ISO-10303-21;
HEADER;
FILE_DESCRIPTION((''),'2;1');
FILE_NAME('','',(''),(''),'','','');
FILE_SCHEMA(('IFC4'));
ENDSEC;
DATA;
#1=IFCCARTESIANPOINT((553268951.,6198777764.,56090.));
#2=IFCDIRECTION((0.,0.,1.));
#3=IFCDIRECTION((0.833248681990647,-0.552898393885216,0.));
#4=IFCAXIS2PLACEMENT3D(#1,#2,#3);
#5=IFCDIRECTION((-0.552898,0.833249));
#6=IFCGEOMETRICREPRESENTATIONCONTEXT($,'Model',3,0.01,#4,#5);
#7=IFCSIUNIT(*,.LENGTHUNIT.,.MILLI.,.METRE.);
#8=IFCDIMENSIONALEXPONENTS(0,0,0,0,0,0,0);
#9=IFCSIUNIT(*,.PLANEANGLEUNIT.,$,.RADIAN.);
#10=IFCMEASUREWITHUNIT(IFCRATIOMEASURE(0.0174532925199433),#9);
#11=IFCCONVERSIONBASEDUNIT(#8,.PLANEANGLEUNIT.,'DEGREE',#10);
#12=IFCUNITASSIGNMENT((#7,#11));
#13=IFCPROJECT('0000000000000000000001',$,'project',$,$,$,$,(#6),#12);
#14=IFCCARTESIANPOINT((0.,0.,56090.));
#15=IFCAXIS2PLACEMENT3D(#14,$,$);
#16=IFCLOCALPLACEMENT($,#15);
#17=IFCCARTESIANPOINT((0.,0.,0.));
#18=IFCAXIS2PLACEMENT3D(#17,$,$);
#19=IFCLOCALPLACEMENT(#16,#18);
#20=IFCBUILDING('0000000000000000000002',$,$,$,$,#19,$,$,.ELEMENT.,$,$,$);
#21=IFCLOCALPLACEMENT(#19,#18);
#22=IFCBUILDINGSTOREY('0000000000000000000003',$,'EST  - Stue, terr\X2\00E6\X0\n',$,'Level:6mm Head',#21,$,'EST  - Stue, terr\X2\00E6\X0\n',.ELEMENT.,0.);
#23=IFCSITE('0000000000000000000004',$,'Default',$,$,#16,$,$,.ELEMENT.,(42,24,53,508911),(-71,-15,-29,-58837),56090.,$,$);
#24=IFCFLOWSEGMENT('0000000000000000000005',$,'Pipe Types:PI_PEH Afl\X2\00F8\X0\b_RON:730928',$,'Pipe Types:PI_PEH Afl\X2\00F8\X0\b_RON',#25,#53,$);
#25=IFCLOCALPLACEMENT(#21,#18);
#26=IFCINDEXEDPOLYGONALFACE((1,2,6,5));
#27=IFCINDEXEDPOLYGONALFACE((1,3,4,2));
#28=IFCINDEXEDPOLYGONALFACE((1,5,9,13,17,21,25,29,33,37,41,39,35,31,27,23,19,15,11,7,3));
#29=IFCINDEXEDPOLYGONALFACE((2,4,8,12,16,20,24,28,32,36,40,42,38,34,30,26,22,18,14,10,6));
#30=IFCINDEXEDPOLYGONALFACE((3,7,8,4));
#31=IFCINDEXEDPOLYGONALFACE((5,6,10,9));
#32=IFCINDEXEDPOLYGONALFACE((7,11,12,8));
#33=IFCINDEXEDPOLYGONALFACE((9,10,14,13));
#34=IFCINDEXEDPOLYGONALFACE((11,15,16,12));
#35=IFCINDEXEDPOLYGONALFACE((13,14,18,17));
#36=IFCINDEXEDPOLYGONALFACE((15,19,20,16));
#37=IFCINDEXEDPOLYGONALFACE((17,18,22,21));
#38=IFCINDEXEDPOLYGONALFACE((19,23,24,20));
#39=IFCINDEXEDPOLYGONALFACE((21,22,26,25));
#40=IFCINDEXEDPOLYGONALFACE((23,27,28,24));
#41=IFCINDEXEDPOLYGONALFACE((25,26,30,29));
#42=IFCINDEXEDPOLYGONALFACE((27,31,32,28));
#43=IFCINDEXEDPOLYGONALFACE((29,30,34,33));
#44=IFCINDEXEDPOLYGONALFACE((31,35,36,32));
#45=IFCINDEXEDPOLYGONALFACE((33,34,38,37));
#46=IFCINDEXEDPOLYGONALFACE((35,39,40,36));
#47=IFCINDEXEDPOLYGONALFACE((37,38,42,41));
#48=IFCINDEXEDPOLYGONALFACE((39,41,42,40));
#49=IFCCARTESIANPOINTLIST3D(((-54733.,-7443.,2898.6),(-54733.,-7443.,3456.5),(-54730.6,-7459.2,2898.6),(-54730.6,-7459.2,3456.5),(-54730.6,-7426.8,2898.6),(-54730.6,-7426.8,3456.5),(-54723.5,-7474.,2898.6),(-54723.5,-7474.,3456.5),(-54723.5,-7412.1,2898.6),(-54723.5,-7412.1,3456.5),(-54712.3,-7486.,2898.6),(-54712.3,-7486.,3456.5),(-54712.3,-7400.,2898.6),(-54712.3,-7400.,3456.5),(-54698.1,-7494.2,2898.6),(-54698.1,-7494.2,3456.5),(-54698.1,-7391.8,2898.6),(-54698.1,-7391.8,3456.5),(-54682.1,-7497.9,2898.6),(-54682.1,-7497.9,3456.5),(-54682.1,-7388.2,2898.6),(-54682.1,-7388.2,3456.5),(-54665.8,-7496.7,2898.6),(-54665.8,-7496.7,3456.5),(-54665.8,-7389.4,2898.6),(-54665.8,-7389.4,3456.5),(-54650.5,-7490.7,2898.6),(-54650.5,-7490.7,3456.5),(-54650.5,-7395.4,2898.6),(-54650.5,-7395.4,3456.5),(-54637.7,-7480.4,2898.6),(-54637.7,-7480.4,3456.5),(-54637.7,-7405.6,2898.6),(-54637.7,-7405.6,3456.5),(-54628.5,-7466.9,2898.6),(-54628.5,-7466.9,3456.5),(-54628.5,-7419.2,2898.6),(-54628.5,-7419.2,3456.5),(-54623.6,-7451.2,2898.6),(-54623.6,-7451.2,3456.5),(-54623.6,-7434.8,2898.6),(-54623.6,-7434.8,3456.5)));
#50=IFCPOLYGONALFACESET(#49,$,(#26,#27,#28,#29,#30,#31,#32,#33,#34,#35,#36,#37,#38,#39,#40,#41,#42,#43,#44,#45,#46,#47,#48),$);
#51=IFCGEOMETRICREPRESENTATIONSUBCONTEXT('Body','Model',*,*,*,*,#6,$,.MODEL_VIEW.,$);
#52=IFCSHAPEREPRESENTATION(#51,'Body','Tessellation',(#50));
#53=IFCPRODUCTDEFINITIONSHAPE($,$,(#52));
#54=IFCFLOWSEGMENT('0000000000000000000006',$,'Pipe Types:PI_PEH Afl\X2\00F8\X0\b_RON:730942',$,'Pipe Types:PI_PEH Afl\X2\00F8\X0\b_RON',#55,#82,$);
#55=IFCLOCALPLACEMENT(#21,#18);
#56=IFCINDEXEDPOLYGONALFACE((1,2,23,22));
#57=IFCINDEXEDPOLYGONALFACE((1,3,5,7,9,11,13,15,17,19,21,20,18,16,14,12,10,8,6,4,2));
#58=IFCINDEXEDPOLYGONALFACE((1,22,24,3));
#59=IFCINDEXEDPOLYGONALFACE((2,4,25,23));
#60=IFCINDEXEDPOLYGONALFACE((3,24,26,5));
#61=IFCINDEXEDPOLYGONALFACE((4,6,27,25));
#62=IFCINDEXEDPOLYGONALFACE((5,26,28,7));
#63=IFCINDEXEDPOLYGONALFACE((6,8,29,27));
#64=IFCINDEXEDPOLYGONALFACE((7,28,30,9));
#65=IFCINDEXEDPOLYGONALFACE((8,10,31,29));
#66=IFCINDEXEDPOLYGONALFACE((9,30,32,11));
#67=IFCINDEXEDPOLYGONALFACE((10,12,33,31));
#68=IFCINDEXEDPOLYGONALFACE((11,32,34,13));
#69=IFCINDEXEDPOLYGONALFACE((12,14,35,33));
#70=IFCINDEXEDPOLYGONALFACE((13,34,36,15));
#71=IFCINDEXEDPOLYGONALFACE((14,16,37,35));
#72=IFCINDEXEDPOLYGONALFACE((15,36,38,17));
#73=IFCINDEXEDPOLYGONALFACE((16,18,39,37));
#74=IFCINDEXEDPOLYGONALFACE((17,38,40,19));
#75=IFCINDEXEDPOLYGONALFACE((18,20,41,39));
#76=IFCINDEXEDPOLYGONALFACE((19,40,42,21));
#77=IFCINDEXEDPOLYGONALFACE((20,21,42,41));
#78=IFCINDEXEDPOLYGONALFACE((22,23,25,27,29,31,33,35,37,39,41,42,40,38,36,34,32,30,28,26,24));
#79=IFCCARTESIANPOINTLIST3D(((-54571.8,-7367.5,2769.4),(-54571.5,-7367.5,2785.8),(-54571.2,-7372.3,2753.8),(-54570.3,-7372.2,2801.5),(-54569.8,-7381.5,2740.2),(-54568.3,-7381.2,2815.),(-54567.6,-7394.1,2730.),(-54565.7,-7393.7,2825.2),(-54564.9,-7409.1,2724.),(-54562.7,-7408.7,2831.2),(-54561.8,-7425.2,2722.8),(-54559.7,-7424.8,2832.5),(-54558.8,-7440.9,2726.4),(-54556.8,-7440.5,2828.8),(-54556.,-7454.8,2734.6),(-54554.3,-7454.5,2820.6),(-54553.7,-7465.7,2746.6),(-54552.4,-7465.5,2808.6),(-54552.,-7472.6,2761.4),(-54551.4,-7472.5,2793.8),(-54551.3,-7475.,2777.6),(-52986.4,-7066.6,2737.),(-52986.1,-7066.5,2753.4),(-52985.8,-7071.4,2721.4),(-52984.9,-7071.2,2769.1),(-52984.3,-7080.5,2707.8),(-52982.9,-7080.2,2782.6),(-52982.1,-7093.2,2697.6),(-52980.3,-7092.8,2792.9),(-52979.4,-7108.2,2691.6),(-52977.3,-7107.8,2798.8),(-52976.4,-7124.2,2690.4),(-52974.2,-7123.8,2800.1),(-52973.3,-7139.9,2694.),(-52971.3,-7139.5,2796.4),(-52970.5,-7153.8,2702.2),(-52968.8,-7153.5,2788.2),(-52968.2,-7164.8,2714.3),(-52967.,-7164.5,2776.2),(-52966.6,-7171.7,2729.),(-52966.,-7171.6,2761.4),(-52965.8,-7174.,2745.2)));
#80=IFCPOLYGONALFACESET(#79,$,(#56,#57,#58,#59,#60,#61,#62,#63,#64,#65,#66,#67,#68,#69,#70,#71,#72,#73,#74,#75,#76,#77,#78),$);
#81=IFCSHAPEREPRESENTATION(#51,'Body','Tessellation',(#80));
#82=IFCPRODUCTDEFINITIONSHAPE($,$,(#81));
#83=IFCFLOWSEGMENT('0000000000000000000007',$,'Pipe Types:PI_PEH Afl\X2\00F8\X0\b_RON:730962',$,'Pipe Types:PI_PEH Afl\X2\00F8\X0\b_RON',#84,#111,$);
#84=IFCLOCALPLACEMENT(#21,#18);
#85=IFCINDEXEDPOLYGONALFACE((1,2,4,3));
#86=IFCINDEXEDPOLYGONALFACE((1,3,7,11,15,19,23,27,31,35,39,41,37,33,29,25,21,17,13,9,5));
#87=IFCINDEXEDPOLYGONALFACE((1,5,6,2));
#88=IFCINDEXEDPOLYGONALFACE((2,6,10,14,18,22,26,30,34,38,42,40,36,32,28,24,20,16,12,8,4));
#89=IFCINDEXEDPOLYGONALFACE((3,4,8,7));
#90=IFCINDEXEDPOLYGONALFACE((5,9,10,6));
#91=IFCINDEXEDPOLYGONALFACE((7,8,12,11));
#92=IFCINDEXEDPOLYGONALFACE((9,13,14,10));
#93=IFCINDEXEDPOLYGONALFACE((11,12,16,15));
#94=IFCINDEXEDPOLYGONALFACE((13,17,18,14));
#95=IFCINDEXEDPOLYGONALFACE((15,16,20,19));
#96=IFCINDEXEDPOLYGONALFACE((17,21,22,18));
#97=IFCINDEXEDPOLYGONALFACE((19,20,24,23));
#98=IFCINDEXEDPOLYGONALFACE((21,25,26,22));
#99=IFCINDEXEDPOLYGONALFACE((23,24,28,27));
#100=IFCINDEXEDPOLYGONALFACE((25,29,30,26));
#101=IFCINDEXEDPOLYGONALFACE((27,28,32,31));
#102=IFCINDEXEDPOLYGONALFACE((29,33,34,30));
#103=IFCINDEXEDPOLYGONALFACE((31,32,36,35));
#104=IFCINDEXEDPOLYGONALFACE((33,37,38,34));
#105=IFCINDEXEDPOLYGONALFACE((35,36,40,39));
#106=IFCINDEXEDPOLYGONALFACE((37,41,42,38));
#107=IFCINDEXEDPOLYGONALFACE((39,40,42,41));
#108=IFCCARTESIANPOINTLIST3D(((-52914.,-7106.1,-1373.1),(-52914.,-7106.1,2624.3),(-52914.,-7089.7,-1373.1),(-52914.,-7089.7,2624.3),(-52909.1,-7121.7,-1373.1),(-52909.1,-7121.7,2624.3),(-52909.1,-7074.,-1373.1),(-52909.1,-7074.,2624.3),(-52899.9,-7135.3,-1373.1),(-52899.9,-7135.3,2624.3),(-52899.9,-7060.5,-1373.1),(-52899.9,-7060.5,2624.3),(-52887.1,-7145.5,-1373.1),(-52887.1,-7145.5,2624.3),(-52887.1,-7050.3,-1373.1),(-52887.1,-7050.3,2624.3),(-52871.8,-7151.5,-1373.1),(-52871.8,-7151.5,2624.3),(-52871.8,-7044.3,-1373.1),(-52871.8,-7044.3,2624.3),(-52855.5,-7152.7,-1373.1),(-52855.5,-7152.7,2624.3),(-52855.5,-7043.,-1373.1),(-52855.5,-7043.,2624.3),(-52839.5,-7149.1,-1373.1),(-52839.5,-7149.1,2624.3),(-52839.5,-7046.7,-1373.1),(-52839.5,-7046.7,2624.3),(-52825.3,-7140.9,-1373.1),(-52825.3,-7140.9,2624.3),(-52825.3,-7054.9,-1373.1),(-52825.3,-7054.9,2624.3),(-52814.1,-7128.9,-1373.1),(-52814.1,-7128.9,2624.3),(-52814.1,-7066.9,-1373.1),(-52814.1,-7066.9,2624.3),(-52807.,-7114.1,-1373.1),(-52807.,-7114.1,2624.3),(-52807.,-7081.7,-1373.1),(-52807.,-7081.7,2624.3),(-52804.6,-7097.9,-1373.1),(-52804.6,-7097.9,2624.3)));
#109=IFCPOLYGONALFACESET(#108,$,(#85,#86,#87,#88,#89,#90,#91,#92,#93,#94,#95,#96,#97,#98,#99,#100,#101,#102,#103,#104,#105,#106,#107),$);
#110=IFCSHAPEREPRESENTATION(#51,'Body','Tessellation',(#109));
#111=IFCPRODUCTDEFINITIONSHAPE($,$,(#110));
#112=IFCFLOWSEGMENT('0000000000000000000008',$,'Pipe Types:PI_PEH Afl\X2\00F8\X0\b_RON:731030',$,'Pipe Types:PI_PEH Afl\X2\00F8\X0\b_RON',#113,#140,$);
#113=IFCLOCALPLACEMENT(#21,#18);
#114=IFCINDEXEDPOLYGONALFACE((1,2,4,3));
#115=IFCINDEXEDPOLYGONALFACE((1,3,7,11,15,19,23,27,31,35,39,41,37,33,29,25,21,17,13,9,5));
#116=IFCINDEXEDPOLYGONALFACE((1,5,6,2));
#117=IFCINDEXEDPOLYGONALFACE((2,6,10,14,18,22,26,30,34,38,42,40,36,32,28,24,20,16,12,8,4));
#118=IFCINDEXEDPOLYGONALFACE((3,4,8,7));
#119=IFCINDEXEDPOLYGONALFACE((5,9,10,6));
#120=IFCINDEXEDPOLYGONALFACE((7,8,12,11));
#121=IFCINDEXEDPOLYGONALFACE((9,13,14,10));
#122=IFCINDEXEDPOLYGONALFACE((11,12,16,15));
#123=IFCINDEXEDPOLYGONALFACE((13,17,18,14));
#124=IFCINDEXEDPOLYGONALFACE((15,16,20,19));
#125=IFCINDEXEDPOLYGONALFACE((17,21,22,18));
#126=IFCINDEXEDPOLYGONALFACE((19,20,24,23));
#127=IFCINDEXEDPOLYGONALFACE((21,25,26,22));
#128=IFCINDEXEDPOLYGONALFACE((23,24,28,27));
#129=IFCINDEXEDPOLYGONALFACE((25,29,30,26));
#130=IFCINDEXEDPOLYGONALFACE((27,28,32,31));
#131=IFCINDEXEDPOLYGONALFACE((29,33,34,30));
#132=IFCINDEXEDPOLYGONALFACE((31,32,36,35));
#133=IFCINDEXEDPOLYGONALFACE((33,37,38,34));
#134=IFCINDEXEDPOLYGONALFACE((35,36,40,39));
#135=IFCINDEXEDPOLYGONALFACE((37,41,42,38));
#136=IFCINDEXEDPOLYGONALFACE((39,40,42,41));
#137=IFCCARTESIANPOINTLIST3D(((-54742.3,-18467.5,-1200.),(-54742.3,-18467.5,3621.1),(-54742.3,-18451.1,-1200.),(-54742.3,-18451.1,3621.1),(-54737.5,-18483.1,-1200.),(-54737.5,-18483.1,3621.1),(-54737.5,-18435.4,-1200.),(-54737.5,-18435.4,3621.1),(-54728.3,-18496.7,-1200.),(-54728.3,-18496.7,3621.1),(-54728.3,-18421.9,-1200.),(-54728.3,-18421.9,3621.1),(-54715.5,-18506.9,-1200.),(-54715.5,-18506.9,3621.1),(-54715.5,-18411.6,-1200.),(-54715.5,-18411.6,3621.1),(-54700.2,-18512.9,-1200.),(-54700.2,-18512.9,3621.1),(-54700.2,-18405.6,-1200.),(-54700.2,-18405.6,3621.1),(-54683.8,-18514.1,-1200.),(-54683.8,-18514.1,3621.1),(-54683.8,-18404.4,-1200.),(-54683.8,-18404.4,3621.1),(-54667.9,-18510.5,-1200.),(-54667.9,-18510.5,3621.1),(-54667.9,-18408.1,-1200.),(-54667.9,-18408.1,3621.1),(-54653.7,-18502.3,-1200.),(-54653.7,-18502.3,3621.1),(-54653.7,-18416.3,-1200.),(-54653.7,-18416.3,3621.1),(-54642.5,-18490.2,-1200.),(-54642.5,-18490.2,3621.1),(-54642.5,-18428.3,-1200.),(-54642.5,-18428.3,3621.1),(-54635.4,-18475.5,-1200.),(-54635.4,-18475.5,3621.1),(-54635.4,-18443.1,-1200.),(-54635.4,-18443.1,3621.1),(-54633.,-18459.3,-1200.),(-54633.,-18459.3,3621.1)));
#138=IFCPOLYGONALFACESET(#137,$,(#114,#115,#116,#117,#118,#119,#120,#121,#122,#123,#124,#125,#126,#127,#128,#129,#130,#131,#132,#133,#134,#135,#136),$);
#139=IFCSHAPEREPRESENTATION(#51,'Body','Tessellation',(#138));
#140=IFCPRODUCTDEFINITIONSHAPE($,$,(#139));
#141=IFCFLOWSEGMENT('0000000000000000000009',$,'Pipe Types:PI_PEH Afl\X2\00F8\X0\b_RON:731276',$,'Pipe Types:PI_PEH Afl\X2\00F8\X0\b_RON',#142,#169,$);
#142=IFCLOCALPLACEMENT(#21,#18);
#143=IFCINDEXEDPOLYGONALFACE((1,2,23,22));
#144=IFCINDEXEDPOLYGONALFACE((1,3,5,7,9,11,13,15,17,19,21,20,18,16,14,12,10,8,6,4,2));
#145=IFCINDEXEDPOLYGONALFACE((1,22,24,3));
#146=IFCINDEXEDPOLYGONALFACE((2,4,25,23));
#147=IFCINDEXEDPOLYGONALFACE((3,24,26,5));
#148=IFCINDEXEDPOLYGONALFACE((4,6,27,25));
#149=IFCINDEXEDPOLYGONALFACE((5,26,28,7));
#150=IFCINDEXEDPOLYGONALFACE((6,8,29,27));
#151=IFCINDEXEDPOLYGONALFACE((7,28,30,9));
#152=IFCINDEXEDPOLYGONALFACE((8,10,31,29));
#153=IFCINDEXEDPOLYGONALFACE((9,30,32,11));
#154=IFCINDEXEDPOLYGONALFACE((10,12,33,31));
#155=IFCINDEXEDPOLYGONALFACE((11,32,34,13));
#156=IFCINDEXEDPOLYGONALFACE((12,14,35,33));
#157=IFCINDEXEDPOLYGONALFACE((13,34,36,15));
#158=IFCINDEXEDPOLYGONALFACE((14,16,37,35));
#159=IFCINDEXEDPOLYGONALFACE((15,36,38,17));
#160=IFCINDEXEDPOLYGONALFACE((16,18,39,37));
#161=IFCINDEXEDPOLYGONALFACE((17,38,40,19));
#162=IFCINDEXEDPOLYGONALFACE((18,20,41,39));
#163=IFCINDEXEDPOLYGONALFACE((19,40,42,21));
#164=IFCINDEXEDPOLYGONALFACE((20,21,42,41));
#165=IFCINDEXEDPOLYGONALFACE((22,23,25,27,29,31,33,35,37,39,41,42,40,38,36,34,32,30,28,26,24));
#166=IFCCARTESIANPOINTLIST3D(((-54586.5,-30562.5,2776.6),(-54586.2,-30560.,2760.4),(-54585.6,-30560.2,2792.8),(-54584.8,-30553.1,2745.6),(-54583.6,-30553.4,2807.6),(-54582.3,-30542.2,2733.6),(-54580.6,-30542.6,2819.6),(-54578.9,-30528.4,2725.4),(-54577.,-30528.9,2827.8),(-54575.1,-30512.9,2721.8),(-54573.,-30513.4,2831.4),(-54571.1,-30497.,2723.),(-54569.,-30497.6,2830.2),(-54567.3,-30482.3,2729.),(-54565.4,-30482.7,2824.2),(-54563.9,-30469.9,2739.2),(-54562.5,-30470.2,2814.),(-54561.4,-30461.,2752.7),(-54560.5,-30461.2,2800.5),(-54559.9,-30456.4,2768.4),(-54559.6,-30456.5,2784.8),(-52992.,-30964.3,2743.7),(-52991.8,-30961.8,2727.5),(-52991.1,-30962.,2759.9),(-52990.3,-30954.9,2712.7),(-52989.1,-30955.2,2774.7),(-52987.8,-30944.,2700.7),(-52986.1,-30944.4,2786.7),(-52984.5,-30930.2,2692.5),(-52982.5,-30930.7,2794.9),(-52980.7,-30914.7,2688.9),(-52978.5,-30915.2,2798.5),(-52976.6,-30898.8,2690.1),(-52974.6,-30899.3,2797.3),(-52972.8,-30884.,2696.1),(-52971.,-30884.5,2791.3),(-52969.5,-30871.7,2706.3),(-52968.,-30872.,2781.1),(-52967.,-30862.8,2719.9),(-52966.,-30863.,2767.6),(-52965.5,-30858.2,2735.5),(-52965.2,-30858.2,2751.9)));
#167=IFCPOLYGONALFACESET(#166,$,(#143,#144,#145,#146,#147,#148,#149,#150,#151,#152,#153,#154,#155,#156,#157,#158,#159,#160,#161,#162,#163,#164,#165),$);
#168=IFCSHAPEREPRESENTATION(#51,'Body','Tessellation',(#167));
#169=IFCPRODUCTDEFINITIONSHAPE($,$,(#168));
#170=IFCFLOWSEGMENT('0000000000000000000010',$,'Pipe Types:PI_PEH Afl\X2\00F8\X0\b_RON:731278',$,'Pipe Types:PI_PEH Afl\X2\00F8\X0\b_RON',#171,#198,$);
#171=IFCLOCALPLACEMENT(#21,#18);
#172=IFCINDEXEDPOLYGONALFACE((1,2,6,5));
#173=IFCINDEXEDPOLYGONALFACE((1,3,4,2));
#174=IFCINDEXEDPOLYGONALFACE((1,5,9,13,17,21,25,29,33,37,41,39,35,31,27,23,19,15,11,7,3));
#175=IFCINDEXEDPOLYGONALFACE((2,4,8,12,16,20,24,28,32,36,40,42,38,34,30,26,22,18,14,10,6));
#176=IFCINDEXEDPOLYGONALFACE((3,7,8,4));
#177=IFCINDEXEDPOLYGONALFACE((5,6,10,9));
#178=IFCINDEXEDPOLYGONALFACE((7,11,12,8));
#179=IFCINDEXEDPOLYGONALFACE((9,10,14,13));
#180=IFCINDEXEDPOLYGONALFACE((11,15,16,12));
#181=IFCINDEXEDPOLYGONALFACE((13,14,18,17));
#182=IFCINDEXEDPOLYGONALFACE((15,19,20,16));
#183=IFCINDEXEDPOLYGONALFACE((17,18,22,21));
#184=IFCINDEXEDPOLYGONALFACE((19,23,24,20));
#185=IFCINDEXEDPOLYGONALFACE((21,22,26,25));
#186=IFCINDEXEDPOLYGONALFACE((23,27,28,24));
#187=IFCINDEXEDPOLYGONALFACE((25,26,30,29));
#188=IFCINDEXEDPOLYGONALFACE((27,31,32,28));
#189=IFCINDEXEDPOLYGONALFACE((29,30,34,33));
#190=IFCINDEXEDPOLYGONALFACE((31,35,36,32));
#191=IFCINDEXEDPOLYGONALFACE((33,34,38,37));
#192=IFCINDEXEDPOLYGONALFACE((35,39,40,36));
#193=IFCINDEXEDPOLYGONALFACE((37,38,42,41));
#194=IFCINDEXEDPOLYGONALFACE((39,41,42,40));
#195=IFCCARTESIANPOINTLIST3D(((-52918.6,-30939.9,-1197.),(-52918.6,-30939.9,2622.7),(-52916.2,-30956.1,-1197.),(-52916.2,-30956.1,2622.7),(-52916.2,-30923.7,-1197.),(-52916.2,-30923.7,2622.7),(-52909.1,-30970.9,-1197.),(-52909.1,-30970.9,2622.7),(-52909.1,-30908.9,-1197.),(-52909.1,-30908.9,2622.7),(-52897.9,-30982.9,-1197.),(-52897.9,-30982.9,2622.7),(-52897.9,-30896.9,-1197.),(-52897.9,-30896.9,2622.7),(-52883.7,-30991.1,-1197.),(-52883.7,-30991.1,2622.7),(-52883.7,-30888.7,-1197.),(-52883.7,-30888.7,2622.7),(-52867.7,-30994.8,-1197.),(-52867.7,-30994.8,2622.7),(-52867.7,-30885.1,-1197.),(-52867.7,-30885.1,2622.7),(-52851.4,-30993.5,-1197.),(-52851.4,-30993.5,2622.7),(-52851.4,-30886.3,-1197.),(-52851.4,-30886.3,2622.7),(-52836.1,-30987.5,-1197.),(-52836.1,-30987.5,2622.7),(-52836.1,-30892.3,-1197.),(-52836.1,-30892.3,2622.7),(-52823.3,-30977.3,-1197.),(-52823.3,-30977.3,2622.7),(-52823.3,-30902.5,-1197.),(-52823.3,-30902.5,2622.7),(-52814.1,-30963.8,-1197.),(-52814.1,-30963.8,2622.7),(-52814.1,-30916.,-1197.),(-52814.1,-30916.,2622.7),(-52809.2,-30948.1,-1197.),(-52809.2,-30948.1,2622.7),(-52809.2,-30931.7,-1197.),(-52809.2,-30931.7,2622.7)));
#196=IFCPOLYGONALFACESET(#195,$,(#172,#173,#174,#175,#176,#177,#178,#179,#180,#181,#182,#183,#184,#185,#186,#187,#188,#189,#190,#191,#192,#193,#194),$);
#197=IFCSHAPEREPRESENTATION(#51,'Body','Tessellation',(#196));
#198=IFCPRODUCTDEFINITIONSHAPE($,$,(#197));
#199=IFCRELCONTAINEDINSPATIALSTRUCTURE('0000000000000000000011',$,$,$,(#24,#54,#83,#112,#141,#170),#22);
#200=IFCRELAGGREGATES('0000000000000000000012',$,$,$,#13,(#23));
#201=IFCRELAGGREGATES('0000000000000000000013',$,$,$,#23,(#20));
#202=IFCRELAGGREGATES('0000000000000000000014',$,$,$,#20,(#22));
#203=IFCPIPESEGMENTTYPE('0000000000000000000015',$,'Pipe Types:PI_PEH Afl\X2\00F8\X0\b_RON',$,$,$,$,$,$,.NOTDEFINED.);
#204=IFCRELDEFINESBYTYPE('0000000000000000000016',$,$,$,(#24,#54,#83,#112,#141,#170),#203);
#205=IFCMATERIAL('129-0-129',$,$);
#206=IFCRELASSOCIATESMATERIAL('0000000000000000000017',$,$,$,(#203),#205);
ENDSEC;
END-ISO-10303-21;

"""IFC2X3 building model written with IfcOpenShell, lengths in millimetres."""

from ifc_helpers import new_model, entity, si_unit, converted_unit, direction, frame, frame_2d, origin, origin_2d_with_axis, place, context, subcontext, project, spatial, circle, extrude, material, type_object, element, save


model = new_model("IFC2X3")

# Units and contexts
model_context = context("Model", 3, precision=0.01, world=frame((553268951.0, 6198777764.0, 56090.0), z_axis=(0.0, 0.0, 1.0), x_axis=(0.833248681990647, -0.552898393885216, 0.0)), true_north=direction((-0.552898, 0.833249)))
body_context = subcontext(model_context, "Body", "Model", "MODEL_VIEW")
ifc_project = project(units=[si_unit("LENGTHUNIT", "METRE", prefix="MILLI"), converted_unit("PLANEANGLEUNIT", "DEGREE", entity("IfcRatioMeasure", 0.0174532925199433), si_unit("PLANEANGLEUNIT", "RADIAN"), dimensions=[0, 0, 0, 0, 0, 0, 0])], contexts=[model_context])

# Site, building, storey
site_placement = place(None, frame((0.0, 0.0, 56090.0)))
site = spatial("IfcSite", under=ifc_project, at=site_placement, Name="Default", CompositionType="ELEMENT", RefLatitude=(42, 24, 53, 508911), RefLongitude=(-71, -15, -29, -58837), RefElevation=56090.0)
building_placement = place(site_placement, origin())
building = spatial("IfcBuilding", under=site, at=building_placement, CompositionType="ELEMENT")
storey_placement = place(building_placement, frame((0.0, 0.0, 0.0)))
storey = spatial("IfcBuildingStorey", under=building, at=storey_placement, Name="EST  - Stue, terræn", ObjectType="Level:6mm Head", LongName="EST  - Stue, terræn", CompositionType="ELEMENT", Elevation=0.0)

# Flow segments
ifc_material_1 = material(Name="129-0-129")
pipe_segment_type_1 = type_object("IfcPipeSegmentType", Name="Pipe Types:PI_PEH Afløb_RON", PredefinedType="NOTDEFINED", material=ifc_material_1)
flow_segment_1_placement = place(storey_placement, origin())
element("IfcFlowSegment", 1, at=flow_segment_1_placement, inside=storey, type_object=pipe_segment_type_1, Name="Pipe Types:PI_PEH Afløb_RON:730928", ObjectType="Pipe Types:PI_PEH Afløb_RON", context=body_context, shape_type="SweptSolid", body=[
    extrude(circle(Radius=55.0, at=origin_2d_with_axis()), frame((-54678.0, -7443.0, 2898.6), z_axis=(0.0, 0.0, 1.0), x_axis=(-1.0, 0.0, 0.0)), (0.0, 0.0, 1.0), 557.9),
])
flow_segment_2_placement = place(storey_placement, origin())
element("IfcFlowSegment", 2, at=flow_segment_2_placement, inside=storey, type_object=pipe_segment_type_1, Name="Pipe Types:PI_PEH Afløb_RON:730942", ObjectType="Pipe Types:PI_PEH Afløb_RON", context=body_context, shape_type="SweptSolid", body=[
    extrude(circle(Radius=55.0, at=frame_2d((0.0, 0.0), x_axis=(1.0, 0.0))), frame((-54561.5, -7420.9, 2777.6), z_axis=(0.982261, 0.186442, -0.020064), x_axis=(0.186479, -0.982459, 0.0)), (0.0, 0.0, 1.0), 1614.1),
])
flow_segment_3_placement = place(storey_placement, origin())
element("IfcFlowSegment", 3, at=flow_segment_3_placement, inside=storey, type_object=pipe_segment_type_1, Name="Pipe Types:PI_PEH Afløb_RON:730962", ObjectType="Pipe Types:PI_PEH Afløb_RON", context=body_context, shape_type="SweptSolid", body=[
    extrude(circle(Radius=55.0, at=origin_2d_with_axis()), frame((-52859.6, -7097.9, -1373.1)), (0.0, 0.0, 1.0), 3997.3),
])
flow_segment_4_placement = place(storey_placement, origin())
element("IfcFlowSegment", 4, at=flow_segment_4_placement, inside=storey, type_object=pipe_segment_type_1, Name="Pipe Types:PI_PEH Afløb_RON:731030", ObjectType="Pipe Types:PI_PEH Afløb_RON", context=body_context, shape_type="SweptSolid", body=[
    extrude(circle(Radius=55.0, at=origin_2d_with_axis()), frame((-54688.0, -18459.3, -1200.0)), (0.0, 0.0, 1.0), 4821.1),
])
flow_segment_5_placement = place(storey_placement, origin())
element("IfcFlowSegment", 5, at=flow_segment_5_placement, inside=storey, type_object=pipe_segment_type_1, Name="Pipe Types:PI_PEH Afløb_RON:731276", ObjectType="Pipe Types:PI_PEH Afløb_RON", context=body_context, shape_type="SweptSolid", body=[
    extrude(circle(Radius=55.0, at=origin_2d_with_axis()), frame((-52978.6, -30910.9, 2743.7), z_axis=(-0.969493, 0.2443, 0.019994), x_axis=(-0.244349, -0.969687, 0.0)), (0.0, 0.0, 1.0), 1644.6),
])
flow_segment_6_placement = place(storey_placement, origin())
element("IfcFlowSegment", 6, at=flow_segment_6_placement, inside=storey, type_object=pipe_segment_type_1, Name="Pipe Types:PI_PEH Afløb_RON:731278", ObjectType="Pipe Types:PI_PEH Afløb_RON", context=body_context, shape_type="SweptSolid", body=[
    extrude(circle(Radius=55.0, at=origin_2d_with_axis()), frame((-52863.6, -30939.9, -1197.0), z_axis=(0.0, 0.0, 1.0), x_axis=(-1.0, 0.0, 0.0)), (0.0, 0.0, 1.0), 3819.7),
])

save(model, "model.ifc")
